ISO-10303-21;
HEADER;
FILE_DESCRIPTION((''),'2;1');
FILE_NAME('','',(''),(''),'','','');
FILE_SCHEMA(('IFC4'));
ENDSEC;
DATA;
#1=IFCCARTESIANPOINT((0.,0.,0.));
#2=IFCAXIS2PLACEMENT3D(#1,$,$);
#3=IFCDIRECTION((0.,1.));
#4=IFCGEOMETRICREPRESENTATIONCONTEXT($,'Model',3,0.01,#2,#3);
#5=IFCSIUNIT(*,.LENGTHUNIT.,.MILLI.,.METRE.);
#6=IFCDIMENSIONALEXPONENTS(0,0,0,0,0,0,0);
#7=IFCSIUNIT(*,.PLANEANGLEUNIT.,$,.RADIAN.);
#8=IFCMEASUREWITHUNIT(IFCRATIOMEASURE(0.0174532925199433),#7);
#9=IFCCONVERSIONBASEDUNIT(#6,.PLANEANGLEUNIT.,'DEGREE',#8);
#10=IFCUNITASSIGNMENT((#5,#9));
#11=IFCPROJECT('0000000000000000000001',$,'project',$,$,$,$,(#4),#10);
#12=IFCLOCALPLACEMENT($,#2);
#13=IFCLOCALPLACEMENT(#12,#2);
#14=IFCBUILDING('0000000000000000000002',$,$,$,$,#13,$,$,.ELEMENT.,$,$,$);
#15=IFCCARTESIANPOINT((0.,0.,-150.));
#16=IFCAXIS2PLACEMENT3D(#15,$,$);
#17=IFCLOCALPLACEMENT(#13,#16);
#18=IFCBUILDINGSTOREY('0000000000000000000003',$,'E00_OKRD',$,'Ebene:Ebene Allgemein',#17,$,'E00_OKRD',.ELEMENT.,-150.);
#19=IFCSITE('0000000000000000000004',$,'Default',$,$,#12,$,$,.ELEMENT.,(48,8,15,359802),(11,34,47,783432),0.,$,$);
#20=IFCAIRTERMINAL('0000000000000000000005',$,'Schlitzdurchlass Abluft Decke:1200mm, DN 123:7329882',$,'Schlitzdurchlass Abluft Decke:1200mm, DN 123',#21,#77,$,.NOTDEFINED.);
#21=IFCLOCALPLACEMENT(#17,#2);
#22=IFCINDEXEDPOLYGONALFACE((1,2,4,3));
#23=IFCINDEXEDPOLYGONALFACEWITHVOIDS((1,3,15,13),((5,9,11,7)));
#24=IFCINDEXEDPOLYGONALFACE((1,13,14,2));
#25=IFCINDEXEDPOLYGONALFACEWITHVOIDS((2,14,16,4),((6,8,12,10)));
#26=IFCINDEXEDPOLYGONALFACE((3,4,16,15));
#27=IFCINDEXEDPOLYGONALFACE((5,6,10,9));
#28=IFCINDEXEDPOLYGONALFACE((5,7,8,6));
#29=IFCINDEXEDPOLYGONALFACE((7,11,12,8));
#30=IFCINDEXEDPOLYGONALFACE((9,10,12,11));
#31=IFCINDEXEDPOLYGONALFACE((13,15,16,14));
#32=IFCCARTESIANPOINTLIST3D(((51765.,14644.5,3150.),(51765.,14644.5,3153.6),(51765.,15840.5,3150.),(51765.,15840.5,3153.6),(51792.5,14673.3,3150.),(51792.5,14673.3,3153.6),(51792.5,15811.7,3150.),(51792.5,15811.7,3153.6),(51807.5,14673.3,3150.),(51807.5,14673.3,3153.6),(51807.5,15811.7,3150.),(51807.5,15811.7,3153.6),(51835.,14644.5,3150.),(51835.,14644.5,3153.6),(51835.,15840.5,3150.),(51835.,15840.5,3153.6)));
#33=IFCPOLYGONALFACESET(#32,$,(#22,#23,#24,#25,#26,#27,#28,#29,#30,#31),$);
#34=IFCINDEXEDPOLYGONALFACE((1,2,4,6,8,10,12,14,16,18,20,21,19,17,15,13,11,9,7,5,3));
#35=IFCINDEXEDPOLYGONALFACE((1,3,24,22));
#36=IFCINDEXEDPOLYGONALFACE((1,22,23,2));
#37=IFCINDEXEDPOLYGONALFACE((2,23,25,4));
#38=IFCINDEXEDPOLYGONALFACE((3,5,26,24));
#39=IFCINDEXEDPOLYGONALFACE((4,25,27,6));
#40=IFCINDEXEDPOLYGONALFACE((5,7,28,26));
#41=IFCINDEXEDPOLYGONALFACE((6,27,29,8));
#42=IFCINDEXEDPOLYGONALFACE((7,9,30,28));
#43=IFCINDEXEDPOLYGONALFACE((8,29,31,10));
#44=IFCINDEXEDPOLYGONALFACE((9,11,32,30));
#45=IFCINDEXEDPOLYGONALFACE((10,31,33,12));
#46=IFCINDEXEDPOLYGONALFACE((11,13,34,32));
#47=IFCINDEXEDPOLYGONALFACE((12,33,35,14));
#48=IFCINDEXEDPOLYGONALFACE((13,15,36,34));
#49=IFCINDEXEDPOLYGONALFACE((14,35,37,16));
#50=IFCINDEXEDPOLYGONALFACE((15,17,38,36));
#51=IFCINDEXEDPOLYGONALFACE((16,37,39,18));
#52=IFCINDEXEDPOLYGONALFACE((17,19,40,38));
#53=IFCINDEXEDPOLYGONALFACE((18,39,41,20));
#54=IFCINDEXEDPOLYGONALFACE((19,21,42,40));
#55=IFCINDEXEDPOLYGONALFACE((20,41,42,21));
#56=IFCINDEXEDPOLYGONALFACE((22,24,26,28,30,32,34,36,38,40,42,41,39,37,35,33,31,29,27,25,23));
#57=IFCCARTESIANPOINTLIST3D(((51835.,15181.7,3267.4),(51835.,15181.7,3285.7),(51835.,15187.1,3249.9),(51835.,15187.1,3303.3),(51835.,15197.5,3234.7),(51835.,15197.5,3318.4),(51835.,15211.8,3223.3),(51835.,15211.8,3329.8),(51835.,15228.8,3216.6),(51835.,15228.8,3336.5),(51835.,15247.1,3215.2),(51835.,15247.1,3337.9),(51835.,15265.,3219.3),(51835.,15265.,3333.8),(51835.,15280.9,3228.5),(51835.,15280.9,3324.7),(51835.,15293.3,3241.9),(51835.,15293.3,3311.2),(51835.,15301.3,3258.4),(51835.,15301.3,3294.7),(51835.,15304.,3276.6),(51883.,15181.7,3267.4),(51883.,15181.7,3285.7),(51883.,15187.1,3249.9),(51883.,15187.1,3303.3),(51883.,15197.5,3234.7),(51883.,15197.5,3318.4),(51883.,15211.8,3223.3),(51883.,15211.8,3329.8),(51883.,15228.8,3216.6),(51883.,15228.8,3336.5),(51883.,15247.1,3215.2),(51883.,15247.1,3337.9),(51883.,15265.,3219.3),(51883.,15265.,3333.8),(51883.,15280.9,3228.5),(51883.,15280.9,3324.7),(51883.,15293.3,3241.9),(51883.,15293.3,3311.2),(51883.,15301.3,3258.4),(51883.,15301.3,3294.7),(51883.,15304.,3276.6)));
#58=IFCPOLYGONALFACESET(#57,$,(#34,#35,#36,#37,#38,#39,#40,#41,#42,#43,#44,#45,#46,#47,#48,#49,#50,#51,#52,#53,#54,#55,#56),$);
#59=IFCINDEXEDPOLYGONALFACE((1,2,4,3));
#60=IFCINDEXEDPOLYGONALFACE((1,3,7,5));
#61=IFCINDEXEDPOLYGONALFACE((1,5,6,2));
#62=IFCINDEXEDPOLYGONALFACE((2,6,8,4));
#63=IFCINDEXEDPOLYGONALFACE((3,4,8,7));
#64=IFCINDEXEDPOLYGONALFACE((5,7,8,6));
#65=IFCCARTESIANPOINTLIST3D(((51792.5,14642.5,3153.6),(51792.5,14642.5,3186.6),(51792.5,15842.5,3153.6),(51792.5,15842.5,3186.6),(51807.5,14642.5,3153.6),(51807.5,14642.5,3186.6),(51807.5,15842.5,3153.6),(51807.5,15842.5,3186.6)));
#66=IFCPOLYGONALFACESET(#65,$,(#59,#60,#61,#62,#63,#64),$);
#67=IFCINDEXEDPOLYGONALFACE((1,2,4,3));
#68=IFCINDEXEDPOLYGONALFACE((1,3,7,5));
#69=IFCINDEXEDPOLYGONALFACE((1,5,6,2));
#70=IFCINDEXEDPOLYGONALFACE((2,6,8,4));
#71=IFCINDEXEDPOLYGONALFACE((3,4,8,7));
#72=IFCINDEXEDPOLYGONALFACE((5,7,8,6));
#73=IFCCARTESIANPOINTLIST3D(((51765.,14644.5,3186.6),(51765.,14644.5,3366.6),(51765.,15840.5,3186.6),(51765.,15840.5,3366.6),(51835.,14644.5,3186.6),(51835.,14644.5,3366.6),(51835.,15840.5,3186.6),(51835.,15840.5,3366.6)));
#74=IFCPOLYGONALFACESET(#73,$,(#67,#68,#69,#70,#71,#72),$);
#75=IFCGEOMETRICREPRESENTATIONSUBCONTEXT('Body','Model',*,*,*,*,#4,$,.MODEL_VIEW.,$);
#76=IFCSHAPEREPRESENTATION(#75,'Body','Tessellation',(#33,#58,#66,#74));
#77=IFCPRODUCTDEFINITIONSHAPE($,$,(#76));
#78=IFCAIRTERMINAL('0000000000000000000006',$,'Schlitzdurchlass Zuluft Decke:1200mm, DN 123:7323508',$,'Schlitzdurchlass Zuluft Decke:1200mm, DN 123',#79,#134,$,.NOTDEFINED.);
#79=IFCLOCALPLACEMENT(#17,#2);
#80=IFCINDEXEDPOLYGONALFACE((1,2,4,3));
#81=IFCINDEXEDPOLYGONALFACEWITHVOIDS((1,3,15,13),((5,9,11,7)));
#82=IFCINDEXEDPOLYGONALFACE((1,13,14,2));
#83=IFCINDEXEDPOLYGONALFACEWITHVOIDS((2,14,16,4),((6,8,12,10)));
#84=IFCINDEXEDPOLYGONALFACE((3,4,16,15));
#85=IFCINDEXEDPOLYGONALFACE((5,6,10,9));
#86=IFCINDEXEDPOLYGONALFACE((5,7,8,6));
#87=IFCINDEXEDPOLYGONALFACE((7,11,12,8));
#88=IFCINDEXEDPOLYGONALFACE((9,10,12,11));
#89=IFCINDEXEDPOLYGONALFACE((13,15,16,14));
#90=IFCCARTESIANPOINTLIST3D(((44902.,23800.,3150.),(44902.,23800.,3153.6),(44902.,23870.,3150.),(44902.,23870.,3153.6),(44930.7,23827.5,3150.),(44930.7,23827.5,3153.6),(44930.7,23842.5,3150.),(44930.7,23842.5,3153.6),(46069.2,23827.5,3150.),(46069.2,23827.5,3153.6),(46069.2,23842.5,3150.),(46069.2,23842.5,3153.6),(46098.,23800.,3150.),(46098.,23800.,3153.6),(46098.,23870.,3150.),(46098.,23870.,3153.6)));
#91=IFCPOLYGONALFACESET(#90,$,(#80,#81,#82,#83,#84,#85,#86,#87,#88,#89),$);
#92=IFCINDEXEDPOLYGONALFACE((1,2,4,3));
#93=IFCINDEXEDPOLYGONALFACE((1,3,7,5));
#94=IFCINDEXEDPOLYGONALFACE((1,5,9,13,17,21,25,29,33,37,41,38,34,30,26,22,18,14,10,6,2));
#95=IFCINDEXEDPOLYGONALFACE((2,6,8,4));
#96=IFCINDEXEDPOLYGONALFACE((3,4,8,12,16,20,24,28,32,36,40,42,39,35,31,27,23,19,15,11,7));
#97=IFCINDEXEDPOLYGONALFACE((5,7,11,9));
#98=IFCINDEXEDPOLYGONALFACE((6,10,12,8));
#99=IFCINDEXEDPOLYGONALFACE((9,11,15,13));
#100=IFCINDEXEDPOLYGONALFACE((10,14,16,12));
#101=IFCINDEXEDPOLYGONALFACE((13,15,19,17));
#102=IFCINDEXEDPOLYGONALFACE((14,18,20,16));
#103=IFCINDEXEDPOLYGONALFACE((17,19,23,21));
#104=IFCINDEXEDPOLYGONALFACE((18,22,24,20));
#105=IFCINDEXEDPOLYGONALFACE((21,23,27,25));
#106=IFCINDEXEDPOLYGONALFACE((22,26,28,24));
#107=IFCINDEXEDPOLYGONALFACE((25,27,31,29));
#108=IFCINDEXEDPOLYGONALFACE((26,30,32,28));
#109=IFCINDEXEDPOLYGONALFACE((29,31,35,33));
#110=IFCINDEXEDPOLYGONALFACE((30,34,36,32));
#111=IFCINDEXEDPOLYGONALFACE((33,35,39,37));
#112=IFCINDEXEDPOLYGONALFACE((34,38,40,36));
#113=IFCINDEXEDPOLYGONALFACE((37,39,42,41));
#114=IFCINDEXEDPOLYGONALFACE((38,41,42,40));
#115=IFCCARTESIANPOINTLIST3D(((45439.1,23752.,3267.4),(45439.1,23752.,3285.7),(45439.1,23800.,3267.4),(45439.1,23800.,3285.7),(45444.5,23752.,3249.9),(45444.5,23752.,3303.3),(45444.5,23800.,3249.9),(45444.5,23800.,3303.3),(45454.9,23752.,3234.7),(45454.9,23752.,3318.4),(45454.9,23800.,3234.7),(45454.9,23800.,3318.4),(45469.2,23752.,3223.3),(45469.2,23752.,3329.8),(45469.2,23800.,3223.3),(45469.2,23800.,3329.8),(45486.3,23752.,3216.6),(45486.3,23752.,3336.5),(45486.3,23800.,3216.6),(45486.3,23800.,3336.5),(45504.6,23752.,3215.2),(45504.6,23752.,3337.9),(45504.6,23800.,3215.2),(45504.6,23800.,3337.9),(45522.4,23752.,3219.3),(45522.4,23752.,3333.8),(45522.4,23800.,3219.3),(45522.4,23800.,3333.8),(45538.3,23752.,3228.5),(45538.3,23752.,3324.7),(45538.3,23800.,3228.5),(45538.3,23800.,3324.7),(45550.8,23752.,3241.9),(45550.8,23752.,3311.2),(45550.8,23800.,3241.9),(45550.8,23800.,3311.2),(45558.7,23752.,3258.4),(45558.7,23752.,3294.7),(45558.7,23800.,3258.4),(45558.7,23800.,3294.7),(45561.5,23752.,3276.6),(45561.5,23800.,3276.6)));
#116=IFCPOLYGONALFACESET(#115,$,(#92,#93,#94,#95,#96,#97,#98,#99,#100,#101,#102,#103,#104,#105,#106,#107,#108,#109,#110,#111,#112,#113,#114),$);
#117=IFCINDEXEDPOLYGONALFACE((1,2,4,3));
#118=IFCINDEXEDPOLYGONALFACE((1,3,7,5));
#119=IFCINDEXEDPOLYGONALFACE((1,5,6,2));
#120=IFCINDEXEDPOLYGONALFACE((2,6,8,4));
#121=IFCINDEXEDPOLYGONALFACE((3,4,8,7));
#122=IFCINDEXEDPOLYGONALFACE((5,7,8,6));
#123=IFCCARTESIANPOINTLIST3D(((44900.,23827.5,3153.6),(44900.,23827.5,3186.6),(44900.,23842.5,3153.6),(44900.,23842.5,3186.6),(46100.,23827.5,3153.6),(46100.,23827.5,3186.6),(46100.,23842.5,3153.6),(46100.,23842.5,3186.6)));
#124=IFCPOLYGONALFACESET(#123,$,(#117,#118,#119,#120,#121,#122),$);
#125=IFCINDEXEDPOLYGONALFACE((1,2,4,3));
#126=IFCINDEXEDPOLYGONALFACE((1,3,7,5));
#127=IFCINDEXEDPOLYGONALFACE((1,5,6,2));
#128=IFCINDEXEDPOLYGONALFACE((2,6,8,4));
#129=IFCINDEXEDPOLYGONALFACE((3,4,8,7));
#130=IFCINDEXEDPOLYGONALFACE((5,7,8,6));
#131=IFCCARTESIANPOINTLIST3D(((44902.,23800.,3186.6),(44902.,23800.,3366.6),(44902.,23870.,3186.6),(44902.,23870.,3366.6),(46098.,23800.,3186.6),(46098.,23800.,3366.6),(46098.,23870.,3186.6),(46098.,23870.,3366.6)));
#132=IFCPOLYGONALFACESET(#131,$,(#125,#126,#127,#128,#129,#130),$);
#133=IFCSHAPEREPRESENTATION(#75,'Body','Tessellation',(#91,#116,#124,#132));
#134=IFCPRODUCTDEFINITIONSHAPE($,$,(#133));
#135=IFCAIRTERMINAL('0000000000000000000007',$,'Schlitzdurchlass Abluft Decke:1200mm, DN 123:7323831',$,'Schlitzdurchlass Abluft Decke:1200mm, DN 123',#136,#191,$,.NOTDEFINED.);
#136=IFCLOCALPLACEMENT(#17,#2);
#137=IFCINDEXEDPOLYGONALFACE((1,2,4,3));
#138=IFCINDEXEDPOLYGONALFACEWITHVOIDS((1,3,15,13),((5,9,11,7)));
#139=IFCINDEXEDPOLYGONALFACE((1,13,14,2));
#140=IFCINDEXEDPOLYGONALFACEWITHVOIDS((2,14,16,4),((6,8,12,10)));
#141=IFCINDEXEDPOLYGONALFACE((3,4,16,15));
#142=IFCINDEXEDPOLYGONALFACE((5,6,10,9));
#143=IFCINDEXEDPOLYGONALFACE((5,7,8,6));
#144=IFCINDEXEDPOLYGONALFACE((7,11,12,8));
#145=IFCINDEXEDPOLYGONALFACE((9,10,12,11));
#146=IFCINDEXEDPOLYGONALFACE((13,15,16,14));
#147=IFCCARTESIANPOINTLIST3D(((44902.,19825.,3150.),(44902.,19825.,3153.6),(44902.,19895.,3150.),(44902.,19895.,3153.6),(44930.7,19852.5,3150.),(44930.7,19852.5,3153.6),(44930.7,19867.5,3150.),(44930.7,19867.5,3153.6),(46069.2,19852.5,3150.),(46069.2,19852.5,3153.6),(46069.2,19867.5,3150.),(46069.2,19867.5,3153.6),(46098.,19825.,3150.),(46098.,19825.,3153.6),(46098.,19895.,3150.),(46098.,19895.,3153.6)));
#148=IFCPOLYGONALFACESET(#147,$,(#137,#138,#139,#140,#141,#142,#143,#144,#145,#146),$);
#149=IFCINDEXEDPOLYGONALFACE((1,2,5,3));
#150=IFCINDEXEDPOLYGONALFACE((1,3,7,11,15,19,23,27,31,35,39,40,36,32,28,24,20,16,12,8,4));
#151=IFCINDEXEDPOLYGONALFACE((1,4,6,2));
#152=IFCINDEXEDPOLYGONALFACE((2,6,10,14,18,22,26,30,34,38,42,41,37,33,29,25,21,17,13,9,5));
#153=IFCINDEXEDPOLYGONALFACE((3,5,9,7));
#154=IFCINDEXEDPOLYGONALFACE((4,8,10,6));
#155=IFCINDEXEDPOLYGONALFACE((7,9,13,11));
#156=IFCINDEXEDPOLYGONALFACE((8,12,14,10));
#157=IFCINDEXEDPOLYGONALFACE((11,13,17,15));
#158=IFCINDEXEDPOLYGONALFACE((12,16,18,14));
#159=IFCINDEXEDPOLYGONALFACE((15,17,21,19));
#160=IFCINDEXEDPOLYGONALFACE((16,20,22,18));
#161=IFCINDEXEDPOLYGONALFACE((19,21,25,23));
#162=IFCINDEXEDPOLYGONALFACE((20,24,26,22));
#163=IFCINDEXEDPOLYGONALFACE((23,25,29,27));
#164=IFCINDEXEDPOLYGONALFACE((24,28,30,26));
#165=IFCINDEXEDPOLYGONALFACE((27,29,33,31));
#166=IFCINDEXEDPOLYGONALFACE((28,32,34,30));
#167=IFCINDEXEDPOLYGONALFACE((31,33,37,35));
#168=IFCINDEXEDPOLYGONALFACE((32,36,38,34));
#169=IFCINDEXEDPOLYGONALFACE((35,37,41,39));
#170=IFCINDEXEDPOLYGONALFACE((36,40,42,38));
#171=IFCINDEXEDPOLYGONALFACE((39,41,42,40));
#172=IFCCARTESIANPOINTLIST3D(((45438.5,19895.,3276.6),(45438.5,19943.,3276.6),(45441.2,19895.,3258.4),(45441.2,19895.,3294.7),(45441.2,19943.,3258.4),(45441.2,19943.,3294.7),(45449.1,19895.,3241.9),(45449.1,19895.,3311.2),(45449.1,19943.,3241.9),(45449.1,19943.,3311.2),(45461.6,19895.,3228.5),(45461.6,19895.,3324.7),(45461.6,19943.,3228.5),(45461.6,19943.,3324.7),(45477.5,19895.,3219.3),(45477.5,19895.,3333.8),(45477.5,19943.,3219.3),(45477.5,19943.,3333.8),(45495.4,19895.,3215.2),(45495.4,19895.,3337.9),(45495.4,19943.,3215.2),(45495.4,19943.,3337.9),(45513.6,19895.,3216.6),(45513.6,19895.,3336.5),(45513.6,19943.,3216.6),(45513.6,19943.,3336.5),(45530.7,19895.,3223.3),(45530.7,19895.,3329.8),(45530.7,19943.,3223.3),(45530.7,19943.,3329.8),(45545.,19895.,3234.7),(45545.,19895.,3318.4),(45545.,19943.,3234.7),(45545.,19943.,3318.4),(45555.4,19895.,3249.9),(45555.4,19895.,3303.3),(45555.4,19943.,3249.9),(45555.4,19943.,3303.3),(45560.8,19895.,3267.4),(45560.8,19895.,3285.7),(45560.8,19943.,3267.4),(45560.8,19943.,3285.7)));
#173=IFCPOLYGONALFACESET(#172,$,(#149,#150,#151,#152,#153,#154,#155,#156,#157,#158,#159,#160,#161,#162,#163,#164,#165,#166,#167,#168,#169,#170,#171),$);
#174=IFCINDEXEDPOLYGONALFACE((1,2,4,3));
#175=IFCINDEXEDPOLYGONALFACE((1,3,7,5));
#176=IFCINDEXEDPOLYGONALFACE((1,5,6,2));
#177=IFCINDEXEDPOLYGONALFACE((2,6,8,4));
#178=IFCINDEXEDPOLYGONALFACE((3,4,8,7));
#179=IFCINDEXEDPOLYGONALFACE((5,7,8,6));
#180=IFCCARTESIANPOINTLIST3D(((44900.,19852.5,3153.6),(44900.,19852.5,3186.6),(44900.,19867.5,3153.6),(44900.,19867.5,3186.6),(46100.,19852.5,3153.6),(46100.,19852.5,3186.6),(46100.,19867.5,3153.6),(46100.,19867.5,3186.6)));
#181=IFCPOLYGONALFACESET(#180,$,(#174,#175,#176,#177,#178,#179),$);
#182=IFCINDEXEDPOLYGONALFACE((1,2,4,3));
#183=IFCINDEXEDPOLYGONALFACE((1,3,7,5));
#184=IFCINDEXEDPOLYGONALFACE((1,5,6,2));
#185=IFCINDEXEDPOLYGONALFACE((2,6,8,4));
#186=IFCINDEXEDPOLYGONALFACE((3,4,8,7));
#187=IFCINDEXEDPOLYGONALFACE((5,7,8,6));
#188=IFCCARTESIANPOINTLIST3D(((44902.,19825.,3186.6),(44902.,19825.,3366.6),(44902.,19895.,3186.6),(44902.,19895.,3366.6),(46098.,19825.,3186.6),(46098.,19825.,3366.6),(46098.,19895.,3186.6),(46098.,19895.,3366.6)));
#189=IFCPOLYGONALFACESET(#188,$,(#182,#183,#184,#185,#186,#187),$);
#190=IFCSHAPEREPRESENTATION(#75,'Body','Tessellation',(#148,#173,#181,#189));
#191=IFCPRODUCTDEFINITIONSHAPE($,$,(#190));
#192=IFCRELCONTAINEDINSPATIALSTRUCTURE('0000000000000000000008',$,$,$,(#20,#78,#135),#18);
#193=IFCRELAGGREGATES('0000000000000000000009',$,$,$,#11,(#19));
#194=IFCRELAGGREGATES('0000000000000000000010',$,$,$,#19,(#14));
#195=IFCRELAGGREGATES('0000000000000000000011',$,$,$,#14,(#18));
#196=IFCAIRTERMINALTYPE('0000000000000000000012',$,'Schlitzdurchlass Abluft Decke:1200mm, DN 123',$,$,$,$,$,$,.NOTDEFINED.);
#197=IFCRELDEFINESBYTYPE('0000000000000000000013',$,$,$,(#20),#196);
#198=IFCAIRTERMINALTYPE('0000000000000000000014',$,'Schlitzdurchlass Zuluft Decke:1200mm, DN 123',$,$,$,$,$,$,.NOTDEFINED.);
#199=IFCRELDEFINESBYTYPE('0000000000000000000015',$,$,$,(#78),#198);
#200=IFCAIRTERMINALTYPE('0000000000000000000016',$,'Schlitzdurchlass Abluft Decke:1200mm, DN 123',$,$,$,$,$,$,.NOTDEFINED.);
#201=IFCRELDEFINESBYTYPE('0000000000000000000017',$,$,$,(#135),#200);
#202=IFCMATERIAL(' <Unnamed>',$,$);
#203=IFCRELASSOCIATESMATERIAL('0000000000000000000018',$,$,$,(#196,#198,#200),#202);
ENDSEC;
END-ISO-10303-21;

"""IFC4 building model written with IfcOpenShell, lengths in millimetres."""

from ifc_helpers import new_model, entity, si_unit, converted_unit, direction, frame, frame_2d, origin, origin_2d_with_axis, place, context, subcontext, project, spatial, polyline, rectangle, circle, outline, extrude, source, transform, mapped, material, type_object, type_shapes, element, save


model = new_model("IFC4")

# Units and contexts
model_context = context("Model", 3, precision=0.01, world=origin(), true_north=direction((0.0, 1.0)))
body_context = subcontext(model_context, "Body", "Model", "MODEL_VIEW")
ifc_project = project(units=[si_unit("LENGTHUNIT", "METRE", prefix="MILLI"), converted_unit("PLANEANGLEUNIT", "DEGREE", entity("IfcRatioMeasure", 0.0174532925199433), si_unit("PLANEANGLEUNIT", "RADIAN"), dimensions=[0, 0, 0, 0, 0, 0, 0])], contexts=[model_context])

# Site, building, storey
site_placement = place(None, origin())
site = spatial("IfcSite", under=ifc_project, at=site_placement, Name="Default", CompositionType="ELEMENT", RefLatitude=(48, 8, 15, 359802), RefLongitude=(11, 34, 47, 783432), RefElevation=0.0)
building_placement = place(site_placement, origin())
building = spatial("IfcBuilding", under=site, at=building_placement, CompositionType="ELEMENT")
storey_placement = place(building_placement, frame((0.0, 0.0, -150.0)))
storey = spatial("IfcBuildingStorey", under=building, at=storey_placement, Name="E00_OKRD", ObjectType="Ebene:Ebene Allgemein", LongName="E00_OKRD", CompositionType="ELEMENT", Elevation=-150.0)

# Air terminal
ifc_material_1 = material(Name=" <Unnamed>")
air_terminal_type_1 = type_object("IfcAirTerminalType", Name="Schlitzdurchlass Abluft Decke:1200mm, DN 123", PredefinedType="NOTDEFINED", material=ifc_material_1)
shared_shape_1 = source(origin(), body_context, "Body", "SweptSolid", [
    extrude(outline(polyline([(-598.0, -35.0), (598.0, -35.0), (598.0, 35.0), (-598.0, 35.0), (-598.0, -35.0)]), holes=[polyline([(-569.2, -7.5), (-569.2, 7.5), (569.2, 7.5), (569.2, -7.5), (-569.2, -7.5)])]), frame((0.0, 0.0, 0.0), z_axis=(0.0, 0.0, 1.0), x_axis=(-1.0, 0.0, 0.0)), (0.0, 0.0, 1.0), 3.6),
    extrude(circle(Radius=61.5, at=frame_2d((0.0, 0.0), x_axis=(1.0, 0.0))), frame((0.0, 35.0, 126.6), z_axis=(0.0, 1.0, 0.0), x_axis=(-1.0, 0.0, 0.0)), (0.0, 0.0, 1.0), 48.0),
    extrude(rectangle(XDim=1200.0, YDim=15.0, at=origin_2d_with_axis()), frame((0.0, 0.0, 3.6), z_axis=(0.0, 0.0, 1.0), x_axis=(-1.0, 0.0, 0.0)), (0.0, 0.0, 1.0), 33.0),
    extrude(rectangle(XDim=1196.0, YDim=70.0, at=origin_2d_with_axis()), frame((0.0, 0.0, 36.6), z_axis=(0.0, 0.0, 1.0), x_axis=(-1.0, 0.0, 0.0)), (0.0, 0.0, 1.0), 180.0),
])
type_shapes(air_terminal_type_1, [shared_shape_1])
for number, where, z_axis, x_axis, name in (
    (1, (51800.0, 15242.5, 3150.0), (0.0, 0.0, 1.0), (0.0, -1.0, 0.0), "Schlitzdurchlass Abluft Decke:1200mm, DN 123:7329882"),
):
    element("IfcAirTerminal", number, at=place(storey_placement, frame(where, z_axis=z_axis, x_axis=x_axis)), inside=storey, type_object=air_terminal_type_1, Name=name, ObjectType="Schlitzdurchlass Abluft Decke:1200mm, DN 123", PredefinedType="NOTDEFINED", context=body_context, shape_type="MappedRepresentation", body=[
        mapped(shared_shape_1, transform((0.0, 0.0, 0.0), scale=1.0)),
    ])

# Air terminals
air_terminal_type_2 = type_object("IfcAirTerminalType", Name="Schlitzdurchlass Zuluft Decke:1200mm, DN 123", PredefinedType="NOTDEFINED", material=ifc_material_1)
shared_shape_2 = source(origin(), body_context, "Body", "SweptSolid", [
    extrude(outline(polyline([(-598.0, -35.0), (598.0, -35.0), (598.0, 35.0), (-598.0, 35.0), (-598.0, -35.0)]), holes=[polyline([(-569.2, -7.5), (-569.2, 7.5), (569.2, 7.5), (569.2, -7.5), (-569.2, -7.5)])]), frame((600.0, 35.0, 0.0), z_axis=(0.0, 0.0, 1.0), x_axis=(-1.0, 0.0, 0.0)), (0.0, 0.0, 1.0), 3.6),
    extrude(circle(Radius=61.5, at=frame_2d((0.0, 0.0), x_axis=(1.0, 0.0))), frame((600.0, 70.0, 126.6), z_axis=(0.0, 1.0, 0.0), x_axis=(-1.0, 0.0, 0.0)), (0.0, 0.0, 1.0), 48.0),
    extrude(rectangle(XDim=1200.0, YDim=15.0, at=origin_2d_with_axis()), frame((600.0, 35.0, 3.6), z_axis=(0.0, 0.0, 1.0), x_axis=(-1.0, 0.0, 0.0)), (0.0, 0.0, 1.0), 33.0),
    extrude(rectangle(XDim=1196.0, YDim=70.0, at=origin_2d_with_axis()), frame((600.0, 35.0, 36.6), z_axis=(0.0, 0.0, 1.0), x_axis=(-1.0, 0.0, 0.0)), (0.0, 0.0, 1.0), 180.0),
])
type_shapes(air_terminal_type_2, [shared_shape_2])
air_terminal_1_placement = place(storey_placement, frame((46100.0, 23870.0, 3150.0), z_axis=(0.0, 0.0, 1.0), x_axis=(-1.0, 0.0, 0.0)))
element("IfcAirTerminal", 2, at=air_terminal_1_placement, inside=storey, type_object=air_terminal_type_2, Name="Schlitzdurchlass Zuluft Decke:1200mm, DN 123:7323508", ObjectType="Schlitzdurchlass Zuluft Decke:1200mm, DN 123", PredefinedType="NOTDEFINED", context=body_context, shape_type="MappedRepresentation", body=[
    mapped(shared_shape_2, transform((0.0, 0.0, 0.0), scale=1.0)),
])
air_terminal_type_3 = type_object("IfcAirTerminalType", Name="Schlitzdurchlass Abluft Decke:1200mm, DN 123", PredefinedType="NOTDEFINED", material=ifc_material_1)
shared_shape_3 = source(origin(), body_context, "Body", "SweptSolid", [
    extrude(outline(polyline([(-598.0, -35.0), (598.0, -35.0), (598.0, 35.0), (-598.0, 35.0), (-598.0, -35.0)]), holes=[polyline([(-569.2, -7.5), (-569.2, 7.5), (569.2, 7.5), (569.2, -7.5), (-569.2, -7.5)])]), frame((0.0, 0.0, 0.0), z_axis=(0.0, 0.0, 1.0), x_axis=(-1.0, 0.0, 0.0)), (0.0, 0.0, 1.0), 3.6),
    extrude(circle(Radius=61.5, at=frame_2d((0.0, 0.0), x_axis=(1.0, 0.0))), frame((0.0, 35.0, 126.6), z_axis=(0.0, 1.0, 0.0), x_axis=(-1.0, 0.0, 0.0)), (0.0, 0.0, 1.0), 48.0),
    extrude(rectangle(XDim=1200.0, YDim=15.0, at=origin_2d_with_axis()), frame((0.0, 0.0, 3.6), z_axis=(0.0, 0.0, 1.0), x_axis=(-1.0, 0.0, 0.0)), (0.0, 0.0, 1.0), 33.0),
    extrude(rectangle(XDim=1196.0, YDim=70.0, at=origin_2d_with_axis()), frame((0.0, 0.0, 36.6), z_axis=(0.0, 0.0, 1.0), x_axis=(-1.0, 0.0, 0.0)), (0.0, 0.0, 1.0), 180.0),
])
type_shapes(air_terminal_type_3, [shared_shape_3])
air_terminal_2_placement = place(storey_placement, frame((45500.0, 19860.0, 3150.0)))
element("IfcAirTerminal", 3, at=air_terminal_2_placement, inside=storey, type_object=air_terminal_type_3, Name="Schlitzdurchlass Abluft Decke:1200mm, DN 123:7323831", ObjectType="Schlitzdurchlass Abluft Decke:1200mm, DN 123", PredefinedType="NOTDEFINED", context=body_context, shape_type="MappedRepresentation", body=[
    mapped(shared_shape_3, transform((0.0, 0.0, 0.0), scale=1.0)),
])

save(model, "model.ifc")
